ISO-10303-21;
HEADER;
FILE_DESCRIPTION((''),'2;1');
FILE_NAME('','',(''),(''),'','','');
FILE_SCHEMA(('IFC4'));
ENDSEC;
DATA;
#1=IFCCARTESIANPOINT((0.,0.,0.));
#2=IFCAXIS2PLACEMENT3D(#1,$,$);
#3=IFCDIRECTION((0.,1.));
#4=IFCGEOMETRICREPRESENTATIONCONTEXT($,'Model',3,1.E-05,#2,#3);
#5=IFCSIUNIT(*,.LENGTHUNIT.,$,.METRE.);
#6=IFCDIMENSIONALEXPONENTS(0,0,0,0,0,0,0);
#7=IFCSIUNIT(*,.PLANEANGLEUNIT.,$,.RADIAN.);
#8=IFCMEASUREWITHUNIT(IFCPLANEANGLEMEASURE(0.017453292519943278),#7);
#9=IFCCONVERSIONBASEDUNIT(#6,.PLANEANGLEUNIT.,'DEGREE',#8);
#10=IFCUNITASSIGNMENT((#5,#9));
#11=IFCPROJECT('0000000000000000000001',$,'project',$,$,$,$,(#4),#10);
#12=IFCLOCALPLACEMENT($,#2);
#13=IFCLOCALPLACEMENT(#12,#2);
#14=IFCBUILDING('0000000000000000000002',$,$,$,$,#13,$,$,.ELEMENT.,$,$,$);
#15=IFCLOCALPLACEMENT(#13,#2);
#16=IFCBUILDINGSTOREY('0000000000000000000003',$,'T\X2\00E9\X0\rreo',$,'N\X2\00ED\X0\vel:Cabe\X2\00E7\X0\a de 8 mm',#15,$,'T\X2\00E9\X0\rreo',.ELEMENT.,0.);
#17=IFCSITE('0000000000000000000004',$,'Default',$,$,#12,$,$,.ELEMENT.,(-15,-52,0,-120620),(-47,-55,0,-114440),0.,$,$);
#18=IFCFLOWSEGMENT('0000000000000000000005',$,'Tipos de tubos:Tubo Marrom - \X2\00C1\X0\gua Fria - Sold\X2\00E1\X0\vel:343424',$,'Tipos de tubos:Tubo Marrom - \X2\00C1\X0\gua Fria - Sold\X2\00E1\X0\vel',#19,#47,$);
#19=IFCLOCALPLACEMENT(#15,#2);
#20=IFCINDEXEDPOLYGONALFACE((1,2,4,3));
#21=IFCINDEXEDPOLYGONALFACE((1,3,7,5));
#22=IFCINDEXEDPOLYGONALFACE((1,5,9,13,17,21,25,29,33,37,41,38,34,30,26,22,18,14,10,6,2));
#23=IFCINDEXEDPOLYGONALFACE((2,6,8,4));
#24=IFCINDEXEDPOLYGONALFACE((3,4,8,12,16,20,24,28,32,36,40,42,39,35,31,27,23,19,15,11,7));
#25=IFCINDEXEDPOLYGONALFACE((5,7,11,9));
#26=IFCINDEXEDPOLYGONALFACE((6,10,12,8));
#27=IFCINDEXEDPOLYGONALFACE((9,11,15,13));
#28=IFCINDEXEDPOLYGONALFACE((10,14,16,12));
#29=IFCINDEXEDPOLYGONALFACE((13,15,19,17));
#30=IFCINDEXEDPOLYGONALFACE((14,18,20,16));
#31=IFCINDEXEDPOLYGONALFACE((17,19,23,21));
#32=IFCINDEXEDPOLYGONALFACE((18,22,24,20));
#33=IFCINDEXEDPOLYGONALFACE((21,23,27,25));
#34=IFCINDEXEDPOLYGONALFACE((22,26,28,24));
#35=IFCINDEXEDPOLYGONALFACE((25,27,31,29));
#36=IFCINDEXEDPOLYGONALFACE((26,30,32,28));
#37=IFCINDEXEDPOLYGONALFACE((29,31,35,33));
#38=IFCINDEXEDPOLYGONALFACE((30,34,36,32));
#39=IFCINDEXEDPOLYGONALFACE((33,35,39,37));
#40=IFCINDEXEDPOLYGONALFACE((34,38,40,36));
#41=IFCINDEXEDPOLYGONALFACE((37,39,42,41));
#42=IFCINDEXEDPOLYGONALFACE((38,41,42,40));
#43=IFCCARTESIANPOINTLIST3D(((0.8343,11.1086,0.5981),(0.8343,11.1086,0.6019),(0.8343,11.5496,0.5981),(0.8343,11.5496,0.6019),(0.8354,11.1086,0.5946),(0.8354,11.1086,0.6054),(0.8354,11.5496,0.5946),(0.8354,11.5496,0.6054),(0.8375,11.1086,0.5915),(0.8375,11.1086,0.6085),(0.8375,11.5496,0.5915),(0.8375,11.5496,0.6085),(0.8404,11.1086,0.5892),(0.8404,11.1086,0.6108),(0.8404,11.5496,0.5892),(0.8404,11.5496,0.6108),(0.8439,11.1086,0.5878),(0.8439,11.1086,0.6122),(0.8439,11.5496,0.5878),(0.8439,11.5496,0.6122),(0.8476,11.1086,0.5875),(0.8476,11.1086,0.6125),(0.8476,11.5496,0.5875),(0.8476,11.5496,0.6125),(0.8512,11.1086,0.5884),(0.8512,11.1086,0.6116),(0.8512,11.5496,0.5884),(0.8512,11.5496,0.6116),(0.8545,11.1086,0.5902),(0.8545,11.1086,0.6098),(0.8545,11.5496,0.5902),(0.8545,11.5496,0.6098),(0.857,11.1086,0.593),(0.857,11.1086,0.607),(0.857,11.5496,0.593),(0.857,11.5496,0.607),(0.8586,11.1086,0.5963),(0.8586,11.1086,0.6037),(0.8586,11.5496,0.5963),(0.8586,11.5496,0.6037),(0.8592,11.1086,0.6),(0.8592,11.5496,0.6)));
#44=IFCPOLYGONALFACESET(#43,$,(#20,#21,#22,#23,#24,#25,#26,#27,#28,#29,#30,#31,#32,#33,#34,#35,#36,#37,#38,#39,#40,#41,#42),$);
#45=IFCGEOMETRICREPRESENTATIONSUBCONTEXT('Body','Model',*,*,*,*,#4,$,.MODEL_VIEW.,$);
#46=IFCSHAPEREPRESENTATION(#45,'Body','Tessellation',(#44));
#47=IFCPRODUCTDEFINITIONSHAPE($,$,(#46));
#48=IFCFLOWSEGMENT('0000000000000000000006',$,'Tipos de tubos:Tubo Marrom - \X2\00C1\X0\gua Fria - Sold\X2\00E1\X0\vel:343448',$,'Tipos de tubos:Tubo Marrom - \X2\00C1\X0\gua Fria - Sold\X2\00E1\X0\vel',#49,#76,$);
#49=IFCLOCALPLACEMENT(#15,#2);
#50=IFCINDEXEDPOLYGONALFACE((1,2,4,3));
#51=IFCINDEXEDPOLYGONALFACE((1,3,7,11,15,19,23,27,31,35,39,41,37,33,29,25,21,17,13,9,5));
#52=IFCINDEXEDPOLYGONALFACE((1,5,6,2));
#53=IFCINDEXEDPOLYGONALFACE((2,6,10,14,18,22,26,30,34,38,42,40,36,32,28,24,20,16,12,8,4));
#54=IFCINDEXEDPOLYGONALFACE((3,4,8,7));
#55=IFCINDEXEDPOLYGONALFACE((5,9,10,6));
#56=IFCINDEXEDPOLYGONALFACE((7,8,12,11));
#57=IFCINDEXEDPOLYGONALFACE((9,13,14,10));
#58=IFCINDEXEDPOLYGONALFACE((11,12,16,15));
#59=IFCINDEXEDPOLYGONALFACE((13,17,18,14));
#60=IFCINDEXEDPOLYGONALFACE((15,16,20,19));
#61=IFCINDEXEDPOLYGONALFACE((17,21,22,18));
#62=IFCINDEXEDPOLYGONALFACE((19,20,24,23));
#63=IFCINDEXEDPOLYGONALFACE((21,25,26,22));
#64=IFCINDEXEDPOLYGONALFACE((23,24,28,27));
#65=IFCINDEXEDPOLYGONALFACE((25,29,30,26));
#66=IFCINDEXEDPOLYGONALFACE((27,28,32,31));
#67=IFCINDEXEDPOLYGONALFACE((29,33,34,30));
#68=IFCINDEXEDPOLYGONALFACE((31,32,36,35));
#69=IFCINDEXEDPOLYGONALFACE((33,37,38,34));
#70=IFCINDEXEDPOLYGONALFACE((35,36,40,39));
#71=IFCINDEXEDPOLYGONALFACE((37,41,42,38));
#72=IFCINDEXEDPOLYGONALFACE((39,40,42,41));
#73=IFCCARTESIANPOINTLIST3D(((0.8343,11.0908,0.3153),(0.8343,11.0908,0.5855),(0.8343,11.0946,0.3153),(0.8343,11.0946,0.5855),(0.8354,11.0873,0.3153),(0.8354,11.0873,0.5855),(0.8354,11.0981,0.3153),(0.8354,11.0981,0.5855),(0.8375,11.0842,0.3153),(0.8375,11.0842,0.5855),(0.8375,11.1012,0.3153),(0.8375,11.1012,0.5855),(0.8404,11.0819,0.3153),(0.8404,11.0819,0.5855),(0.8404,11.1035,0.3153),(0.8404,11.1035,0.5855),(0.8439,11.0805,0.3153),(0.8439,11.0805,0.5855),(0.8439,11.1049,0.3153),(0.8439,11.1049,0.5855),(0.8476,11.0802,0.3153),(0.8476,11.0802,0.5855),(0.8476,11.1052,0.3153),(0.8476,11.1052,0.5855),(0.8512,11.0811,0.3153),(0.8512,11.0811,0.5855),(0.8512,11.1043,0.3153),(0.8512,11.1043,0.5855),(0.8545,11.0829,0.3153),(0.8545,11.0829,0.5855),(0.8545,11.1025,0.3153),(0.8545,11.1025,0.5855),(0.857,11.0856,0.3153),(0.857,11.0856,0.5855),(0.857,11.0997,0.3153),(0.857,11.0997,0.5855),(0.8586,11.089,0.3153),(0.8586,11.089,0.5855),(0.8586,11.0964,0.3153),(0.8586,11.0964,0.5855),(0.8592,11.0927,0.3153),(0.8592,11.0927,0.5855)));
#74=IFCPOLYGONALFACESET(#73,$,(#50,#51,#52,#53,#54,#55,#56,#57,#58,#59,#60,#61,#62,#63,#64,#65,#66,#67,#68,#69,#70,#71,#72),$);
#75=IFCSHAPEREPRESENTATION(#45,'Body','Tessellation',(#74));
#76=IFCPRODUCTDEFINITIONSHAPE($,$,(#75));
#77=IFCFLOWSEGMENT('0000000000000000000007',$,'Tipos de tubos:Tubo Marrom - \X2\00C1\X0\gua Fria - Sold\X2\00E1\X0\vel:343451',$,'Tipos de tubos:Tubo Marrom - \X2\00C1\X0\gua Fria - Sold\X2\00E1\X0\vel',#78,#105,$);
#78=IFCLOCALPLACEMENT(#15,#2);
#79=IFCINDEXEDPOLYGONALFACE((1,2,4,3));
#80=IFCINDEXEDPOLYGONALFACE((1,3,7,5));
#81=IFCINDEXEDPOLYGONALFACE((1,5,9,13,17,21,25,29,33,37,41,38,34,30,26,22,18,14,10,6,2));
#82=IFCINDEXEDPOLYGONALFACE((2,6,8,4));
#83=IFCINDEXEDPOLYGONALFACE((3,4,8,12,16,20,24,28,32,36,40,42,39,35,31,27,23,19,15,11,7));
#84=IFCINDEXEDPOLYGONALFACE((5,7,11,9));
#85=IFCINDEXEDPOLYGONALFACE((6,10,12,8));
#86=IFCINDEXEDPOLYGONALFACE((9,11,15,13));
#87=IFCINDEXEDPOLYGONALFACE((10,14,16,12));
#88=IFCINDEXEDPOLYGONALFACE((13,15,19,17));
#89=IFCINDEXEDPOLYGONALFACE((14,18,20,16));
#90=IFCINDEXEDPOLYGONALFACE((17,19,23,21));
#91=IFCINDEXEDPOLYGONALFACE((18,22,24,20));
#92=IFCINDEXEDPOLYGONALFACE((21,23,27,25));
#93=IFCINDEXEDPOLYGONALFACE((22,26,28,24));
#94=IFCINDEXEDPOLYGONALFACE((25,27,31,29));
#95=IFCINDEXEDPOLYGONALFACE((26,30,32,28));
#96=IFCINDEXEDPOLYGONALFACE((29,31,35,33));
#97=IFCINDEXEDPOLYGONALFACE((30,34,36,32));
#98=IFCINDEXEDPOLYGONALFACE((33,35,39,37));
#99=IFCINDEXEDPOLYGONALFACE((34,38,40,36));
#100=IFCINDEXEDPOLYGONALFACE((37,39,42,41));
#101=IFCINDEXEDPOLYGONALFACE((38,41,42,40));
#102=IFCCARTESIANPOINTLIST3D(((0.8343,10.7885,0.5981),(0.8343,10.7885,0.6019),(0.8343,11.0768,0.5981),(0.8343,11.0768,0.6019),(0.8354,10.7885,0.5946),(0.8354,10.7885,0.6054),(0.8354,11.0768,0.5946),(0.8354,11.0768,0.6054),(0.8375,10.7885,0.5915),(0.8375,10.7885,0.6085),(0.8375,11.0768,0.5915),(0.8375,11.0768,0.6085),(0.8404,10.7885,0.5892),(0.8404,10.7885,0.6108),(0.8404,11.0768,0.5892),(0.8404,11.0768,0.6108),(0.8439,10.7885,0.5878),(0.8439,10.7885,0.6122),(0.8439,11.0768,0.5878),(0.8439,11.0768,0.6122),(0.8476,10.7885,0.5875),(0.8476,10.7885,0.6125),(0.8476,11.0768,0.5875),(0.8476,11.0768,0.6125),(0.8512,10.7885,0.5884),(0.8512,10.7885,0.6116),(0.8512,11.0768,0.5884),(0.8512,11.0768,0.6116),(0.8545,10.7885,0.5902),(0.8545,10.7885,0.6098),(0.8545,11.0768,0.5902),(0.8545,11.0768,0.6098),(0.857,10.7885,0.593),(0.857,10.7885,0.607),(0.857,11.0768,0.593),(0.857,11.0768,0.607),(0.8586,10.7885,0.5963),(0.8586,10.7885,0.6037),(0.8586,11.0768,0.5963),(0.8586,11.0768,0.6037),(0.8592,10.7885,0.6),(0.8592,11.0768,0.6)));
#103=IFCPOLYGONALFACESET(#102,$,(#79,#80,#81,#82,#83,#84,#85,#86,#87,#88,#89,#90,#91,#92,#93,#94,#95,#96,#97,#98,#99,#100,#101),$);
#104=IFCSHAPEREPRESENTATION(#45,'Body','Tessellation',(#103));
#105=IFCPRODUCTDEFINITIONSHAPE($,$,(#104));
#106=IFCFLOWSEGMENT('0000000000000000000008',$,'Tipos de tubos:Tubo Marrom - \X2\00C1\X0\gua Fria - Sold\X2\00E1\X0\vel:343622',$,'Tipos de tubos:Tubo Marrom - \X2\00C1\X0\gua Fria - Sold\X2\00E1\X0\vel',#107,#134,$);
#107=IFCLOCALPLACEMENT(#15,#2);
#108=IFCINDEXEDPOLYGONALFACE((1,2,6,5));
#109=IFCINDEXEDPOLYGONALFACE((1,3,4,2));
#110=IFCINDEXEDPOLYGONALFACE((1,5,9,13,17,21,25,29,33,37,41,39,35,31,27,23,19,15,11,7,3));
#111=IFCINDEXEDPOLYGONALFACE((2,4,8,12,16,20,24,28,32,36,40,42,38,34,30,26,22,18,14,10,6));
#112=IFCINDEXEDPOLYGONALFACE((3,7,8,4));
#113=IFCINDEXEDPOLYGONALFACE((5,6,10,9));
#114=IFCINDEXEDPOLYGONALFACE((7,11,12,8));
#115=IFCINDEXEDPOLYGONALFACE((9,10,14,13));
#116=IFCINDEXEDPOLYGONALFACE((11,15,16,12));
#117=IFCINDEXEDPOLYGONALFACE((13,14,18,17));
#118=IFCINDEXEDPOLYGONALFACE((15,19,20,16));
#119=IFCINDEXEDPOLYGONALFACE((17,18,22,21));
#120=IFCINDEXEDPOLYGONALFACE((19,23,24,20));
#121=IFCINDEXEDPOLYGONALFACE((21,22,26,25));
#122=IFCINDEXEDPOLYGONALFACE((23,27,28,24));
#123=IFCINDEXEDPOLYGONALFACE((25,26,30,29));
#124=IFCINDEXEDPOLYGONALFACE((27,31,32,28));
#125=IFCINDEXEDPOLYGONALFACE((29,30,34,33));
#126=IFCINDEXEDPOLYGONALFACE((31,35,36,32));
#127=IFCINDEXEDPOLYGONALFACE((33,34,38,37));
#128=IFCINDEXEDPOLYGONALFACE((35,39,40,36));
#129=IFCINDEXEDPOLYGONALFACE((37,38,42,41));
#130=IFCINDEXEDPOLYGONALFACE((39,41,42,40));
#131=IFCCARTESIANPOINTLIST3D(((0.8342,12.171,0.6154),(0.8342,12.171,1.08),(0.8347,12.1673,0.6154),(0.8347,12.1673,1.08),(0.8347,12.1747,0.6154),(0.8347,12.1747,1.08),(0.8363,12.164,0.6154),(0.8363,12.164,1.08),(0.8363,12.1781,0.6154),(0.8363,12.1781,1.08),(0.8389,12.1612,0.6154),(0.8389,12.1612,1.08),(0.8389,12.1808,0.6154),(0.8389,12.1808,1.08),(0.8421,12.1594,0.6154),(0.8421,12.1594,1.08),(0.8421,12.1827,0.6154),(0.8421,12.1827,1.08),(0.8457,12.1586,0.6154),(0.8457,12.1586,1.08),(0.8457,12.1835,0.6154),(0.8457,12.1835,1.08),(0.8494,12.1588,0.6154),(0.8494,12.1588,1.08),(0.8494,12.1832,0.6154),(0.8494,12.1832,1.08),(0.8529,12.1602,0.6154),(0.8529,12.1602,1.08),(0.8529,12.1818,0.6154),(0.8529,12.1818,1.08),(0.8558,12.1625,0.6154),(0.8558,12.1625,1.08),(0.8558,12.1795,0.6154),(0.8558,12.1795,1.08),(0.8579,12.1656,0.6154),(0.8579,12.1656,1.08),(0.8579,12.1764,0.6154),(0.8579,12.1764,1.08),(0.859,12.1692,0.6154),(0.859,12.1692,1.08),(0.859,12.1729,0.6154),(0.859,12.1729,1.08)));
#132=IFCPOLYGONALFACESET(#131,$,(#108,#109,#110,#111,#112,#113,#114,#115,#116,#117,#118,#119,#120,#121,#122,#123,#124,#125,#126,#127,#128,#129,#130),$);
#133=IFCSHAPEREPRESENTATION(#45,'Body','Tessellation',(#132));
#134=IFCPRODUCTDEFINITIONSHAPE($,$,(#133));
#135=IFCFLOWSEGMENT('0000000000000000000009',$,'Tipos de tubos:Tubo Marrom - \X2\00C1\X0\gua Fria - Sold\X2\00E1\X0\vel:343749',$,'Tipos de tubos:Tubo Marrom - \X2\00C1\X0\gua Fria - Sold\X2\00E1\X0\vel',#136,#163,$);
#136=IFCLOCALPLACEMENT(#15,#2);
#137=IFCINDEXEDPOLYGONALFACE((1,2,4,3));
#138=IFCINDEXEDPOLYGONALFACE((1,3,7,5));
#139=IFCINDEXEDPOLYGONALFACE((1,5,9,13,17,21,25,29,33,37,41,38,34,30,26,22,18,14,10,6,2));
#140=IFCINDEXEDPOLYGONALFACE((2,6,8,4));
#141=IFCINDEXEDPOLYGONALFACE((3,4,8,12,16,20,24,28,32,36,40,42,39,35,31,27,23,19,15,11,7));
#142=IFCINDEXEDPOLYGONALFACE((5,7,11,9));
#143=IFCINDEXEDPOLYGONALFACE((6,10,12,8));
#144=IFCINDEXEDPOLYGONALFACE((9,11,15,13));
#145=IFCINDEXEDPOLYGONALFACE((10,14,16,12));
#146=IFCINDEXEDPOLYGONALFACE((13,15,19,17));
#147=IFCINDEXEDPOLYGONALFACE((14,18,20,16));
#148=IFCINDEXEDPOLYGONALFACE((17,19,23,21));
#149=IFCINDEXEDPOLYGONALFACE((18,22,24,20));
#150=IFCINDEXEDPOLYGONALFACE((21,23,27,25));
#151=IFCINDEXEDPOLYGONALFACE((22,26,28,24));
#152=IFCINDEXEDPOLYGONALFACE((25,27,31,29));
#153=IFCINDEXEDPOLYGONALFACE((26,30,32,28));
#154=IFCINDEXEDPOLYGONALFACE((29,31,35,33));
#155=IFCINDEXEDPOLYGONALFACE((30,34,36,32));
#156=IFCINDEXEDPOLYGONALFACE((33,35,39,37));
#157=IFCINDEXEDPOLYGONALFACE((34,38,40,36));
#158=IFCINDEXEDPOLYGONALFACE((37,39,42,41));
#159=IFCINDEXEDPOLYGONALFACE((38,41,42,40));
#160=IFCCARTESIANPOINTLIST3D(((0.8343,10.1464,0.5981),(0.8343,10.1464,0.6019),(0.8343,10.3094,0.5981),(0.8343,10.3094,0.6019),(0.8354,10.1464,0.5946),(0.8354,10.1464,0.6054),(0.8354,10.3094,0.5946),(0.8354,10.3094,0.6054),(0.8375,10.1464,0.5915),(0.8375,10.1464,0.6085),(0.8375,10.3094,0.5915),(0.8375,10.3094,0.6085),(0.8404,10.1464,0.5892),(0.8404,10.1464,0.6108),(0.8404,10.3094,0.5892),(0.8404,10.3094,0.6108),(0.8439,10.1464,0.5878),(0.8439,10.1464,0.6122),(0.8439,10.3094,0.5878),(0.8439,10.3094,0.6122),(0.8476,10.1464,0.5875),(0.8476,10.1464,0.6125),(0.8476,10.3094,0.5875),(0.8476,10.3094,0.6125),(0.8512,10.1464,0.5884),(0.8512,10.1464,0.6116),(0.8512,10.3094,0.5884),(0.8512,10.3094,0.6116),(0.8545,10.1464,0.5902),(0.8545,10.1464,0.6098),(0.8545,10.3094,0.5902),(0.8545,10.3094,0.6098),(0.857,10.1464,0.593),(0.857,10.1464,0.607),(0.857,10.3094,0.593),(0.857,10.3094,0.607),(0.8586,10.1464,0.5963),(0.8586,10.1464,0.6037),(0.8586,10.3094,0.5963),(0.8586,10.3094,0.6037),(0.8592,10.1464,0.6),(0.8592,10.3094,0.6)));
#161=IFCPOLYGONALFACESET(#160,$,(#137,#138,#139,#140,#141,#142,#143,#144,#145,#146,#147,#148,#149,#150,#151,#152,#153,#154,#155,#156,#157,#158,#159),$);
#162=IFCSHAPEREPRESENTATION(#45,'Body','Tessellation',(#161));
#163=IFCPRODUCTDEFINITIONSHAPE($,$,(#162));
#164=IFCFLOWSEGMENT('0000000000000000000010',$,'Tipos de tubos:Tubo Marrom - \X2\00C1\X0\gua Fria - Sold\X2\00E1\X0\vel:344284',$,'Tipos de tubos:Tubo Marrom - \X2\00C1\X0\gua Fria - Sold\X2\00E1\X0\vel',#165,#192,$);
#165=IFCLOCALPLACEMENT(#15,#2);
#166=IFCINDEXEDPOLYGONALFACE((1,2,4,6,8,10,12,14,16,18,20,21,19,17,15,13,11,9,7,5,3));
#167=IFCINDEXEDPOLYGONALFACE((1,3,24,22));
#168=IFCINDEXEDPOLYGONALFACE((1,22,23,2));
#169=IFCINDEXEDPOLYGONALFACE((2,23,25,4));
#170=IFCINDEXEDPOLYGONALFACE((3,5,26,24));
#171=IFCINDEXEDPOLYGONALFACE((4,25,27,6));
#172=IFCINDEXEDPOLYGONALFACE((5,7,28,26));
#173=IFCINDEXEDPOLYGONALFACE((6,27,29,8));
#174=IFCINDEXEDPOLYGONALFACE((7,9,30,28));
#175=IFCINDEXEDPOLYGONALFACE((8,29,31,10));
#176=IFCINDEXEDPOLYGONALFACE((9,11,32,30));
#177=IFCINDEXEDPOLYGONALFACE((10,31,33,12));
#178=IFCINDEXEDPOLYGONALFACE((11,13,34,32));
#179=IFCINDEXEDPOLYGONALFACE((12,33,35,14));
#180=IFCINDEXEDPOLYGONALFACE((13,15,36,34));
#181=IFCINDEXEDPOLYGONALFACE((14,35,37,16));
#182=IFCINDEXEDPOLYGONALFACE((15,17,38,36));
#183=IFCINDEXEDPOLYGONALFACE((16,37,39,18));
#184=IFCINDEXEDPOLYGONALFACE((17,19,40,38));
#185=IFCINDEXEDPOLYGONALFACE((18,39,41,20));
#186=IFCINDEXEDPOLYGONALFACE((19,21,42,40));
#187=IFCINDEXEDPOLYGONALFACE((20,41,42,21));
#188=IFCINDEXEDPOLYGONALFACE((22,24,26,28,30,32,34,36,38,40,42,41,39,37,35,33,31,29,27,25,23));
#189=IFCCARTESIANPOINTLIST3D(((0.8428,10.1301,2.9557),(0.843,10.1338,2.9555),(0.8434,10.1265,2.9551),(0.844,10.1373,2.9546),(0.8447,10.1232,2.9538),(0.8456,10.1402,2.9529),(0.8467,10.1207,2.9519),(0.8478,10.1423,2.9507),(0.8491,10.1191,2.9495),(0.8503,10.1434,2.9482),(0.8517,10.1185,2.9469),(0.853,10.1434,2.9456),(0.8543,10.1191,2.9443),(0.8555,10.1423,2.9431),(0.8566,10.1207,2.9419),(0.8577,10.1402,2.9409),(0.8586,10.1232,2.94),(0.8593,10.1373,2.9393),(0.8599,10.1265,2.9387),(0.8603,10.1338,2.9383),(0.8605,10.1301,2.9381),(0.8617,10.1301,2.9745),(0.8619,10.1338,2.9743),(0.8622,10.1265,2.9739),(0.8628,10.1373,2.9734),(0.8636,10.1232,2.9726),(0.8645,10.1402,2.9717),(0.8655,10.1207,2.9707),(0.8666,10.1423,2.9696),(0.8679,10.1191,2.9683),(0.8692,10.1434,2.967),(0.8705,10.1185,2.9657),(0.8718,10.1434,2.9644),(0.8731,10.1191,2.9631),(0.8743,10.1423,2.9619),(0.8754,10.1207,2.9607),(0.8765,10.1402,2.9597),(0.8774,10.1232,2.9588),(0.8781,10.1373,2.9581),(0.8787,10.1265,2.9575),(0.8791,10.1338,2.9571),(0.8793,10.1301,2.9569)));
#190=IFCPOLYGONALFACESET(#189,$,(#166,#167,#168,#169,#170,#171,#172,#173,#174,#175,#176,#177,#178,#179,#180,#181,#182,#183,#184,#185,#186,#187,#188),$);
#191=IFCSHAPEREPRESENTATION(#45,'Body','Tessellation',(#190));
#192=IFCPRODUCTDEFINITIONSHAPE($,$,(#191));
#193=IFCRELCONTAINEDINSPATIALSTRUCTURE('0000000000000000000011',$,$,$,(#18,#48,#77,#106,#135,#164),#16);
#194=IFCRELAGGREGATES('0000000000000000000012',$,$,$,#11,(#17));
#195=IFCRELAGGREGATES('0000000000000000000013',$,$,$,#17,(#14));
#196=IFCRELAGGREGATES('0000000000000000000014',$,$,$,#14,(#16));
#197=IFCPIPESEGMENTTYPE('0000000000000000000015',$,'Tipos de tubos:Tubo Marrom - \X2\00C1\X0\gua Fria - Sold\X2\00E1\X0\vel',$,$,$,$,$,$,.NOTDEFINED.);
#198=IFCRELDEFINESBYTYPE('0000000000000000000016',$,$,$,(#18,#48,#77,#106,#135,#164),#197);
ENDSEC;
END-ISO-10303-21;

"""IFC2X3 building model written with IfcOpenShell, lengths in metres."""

from ifc_helpers import new_model, entity, si_unit, converted_unit, direction, frame, frame_2d, origin, origin_2d_with_axis, place, context, subcontext, project, spatial, circle, extrude, type_object, element, save


model = new_model("IFC2X3")

# Units and contexts
model_context = context("Model", 3, precision=1e-05, world=origin(), true_north=direction((0.0, 1.0)))
body_context = subcontext(model_context, "Body", "Model", "MODEL_VIEW")
ifc_project = project(units=[si_unit("LENGTHUNIT", "METRE"), converted_unit("PLANEANGLEUNIT", "DEGREE", entity("IfcPlaneAngleMeasure", 0.017453292519943278), si_unit("PLANEANGLEUNIT", "RADIAN"), dimensions=[0, 0, 0, 0, 0, 0, 0])], contexts=[model_context])

# Site, building, storey
site_placement = place(None, origin())
site = spatial("IfcSite", under=ifc_project, at=site_placement, Name="Default", CompositionType="ELEMENT", RefLatitude=(-15, -52, 0, -120620), RefLongitude=(-47, -55, 0, -114440), RefElevation=0.0)
building_placement = place(site_placement, origin())
building = spatial("IfcBuilding", under=site, at=building_placement, CompositionType="ELEMENT")
storey_placement = place(building_placement, origin())
storey = spatial("IfcBuildingStorey", under=building, at=storey_placement, Name="Térreo", ObjectType="Nível:Cabeça de 8 mm", LongName="Térreo", CompositionType="ELEMENT", Elevation=0.0)

# Flow segments
pipe_segment_type = type_object("IfcPipeSegmentType", Name="Tipos de tubos:Tubo Marrom - Água Fria - Soldável", PredefinedType="NOTDEFINED")
flow_segment_1_placement = place(storey_placement, origin())
element("IfcFlowSegment", 1, at=flow_segment_1_placement, inside=storey, type_object=pipe_segment_type, Name="Tipos de tubos:Tubo Marrom - Água Fria - Soldável:343424", ObjectType="Tipos de tubos:Tubo Marrom - Água Fria - Soldável", context=body_context, shape_type="SweptSolid", body=[
    extrude(circle(Radius=0.0125, at=origin_2d_with_axis()), frame((0.8467, 11.1086, 0.6), z_axis=(0.0, 1.0, 0.0), x_axis=(1.0, 0.0, 0.0)), (0.0, 0.0, 1.0), 0.441),
])
flow_segment_2_placement = place(storey_placement, origin())
element("IfcFlowSegment", 2, at=flow_segment_2_placement, inside=storey, type_object=pipe_segment_type, Name="Tipos de tubos:Tubo Marrom - Água Fria - Soldável:343448", ObjectType="Tipos de tubos:Tubo Marrom - Água Fria - Soldável", context=body_context, shape_type="SweptSolid", body=[
    extrude(circle(Radius=0.0125, at=origin_2d_with_axis()), frame((0.8467, 11.0927, 0.3153)), (0.0, 0.0, 1.0), 0.2702),
])
flow_segment_3_placement = place(storey_placement, origin())
element("IfcFlowSegment", 3, at=flow_segment_3_placement, inside=storey, type_object=pipe_segment_type, Name="Tipos de tubos:Tubo Marrom - Água Fria - Soldável:343451", ObjectType="Tipos de tubos:Tubo Marrom - Água Fria - Soldável", context=body_context, shape_type="SweptSolid", body=[
    extrude(circle(Radius=0.0125, at=origin_2d_with_axis()), frame((0.8467, 10.7885, 0.6), z_axis=(0.0, 1.0, 0.0), x_axis=(1.0, 0.0, 0.0)), (0.0, 0.0, 1.0), 0.2883),
])
flow_segment_4_placement = place(storey_placement, origin())
element("IfcFlowSegment", 4, at=flow_segment_4_placement, inside=storey, type_object=pipe_segment_type, Name="Tipos de tubos:Tubo Marrom - Água Fria - Soldável:343622", ObjectType="Tipos de tubos:Tubo Marrom - Água Fria - Soldável", context=body_context, shape_type="SweptSolid", body=[
    extrude(circle(Radius=0.0125, at=frame_2d((0.0, 0.0), x_axis=(1.0, 0.0))), frame((0.8467, 12.171, 0.6154), z_axis=(0.0, 0.0, 1.0), x_axis=(-1.0, 0.0, 0.0)), (0.0, 0.0, 1.0), 0.4646),
])
flow_segment_5_placement = place(storey_placement, origin())
element("IfcFlowSegment", 5, at=flow_segment_5_placement, inside=storey, type_object=pipe_segment_type, Name="Tipos de tubos:Tubo Marrom - Água Fria - Soldável:343749", ObjectType="Tipos de tubos:Tubo Marrom - Água Fria - Soldável", context=body_context, shape_type="SweptSolid", body=[
    extrude(circle(Radius=0.0125, at=origin_2d_with_axis()), frame((0.8467, 10.1464, 0.6), z_axis=(0.0, 1.0, 0.0), x_axis=(1.0, 0.0, 0.0)), (0.0, 0.0, 1.0), 0.163),
])
flow_segment_6_placement = place(storey_placement, origin())
element("IfcFlowSegment", 6, at=flow_segment_6_placement, inside=storey, type_object=pipe_segment_type, Name="Tipos de tubos:Tubo Marrom - Água Fria - Soldável:344284", ObjectType="Tipos de tubos:Tubo Marrom - Água Fria - Soldável", context=body_context, shape_type="SweptSolid", body=[
    extrude(circle(Radius=0.0125, at=origin_2d_with_axis()), frame((0.8517, 10.131, 2.9469), z_axis=(0.707107, 0.0, 0.707107), x_axis=(0.0, -1.0, 0.0)), (0.0, 0.0, 1.0), 0.0266),
])

save(model, "model.ifc")
